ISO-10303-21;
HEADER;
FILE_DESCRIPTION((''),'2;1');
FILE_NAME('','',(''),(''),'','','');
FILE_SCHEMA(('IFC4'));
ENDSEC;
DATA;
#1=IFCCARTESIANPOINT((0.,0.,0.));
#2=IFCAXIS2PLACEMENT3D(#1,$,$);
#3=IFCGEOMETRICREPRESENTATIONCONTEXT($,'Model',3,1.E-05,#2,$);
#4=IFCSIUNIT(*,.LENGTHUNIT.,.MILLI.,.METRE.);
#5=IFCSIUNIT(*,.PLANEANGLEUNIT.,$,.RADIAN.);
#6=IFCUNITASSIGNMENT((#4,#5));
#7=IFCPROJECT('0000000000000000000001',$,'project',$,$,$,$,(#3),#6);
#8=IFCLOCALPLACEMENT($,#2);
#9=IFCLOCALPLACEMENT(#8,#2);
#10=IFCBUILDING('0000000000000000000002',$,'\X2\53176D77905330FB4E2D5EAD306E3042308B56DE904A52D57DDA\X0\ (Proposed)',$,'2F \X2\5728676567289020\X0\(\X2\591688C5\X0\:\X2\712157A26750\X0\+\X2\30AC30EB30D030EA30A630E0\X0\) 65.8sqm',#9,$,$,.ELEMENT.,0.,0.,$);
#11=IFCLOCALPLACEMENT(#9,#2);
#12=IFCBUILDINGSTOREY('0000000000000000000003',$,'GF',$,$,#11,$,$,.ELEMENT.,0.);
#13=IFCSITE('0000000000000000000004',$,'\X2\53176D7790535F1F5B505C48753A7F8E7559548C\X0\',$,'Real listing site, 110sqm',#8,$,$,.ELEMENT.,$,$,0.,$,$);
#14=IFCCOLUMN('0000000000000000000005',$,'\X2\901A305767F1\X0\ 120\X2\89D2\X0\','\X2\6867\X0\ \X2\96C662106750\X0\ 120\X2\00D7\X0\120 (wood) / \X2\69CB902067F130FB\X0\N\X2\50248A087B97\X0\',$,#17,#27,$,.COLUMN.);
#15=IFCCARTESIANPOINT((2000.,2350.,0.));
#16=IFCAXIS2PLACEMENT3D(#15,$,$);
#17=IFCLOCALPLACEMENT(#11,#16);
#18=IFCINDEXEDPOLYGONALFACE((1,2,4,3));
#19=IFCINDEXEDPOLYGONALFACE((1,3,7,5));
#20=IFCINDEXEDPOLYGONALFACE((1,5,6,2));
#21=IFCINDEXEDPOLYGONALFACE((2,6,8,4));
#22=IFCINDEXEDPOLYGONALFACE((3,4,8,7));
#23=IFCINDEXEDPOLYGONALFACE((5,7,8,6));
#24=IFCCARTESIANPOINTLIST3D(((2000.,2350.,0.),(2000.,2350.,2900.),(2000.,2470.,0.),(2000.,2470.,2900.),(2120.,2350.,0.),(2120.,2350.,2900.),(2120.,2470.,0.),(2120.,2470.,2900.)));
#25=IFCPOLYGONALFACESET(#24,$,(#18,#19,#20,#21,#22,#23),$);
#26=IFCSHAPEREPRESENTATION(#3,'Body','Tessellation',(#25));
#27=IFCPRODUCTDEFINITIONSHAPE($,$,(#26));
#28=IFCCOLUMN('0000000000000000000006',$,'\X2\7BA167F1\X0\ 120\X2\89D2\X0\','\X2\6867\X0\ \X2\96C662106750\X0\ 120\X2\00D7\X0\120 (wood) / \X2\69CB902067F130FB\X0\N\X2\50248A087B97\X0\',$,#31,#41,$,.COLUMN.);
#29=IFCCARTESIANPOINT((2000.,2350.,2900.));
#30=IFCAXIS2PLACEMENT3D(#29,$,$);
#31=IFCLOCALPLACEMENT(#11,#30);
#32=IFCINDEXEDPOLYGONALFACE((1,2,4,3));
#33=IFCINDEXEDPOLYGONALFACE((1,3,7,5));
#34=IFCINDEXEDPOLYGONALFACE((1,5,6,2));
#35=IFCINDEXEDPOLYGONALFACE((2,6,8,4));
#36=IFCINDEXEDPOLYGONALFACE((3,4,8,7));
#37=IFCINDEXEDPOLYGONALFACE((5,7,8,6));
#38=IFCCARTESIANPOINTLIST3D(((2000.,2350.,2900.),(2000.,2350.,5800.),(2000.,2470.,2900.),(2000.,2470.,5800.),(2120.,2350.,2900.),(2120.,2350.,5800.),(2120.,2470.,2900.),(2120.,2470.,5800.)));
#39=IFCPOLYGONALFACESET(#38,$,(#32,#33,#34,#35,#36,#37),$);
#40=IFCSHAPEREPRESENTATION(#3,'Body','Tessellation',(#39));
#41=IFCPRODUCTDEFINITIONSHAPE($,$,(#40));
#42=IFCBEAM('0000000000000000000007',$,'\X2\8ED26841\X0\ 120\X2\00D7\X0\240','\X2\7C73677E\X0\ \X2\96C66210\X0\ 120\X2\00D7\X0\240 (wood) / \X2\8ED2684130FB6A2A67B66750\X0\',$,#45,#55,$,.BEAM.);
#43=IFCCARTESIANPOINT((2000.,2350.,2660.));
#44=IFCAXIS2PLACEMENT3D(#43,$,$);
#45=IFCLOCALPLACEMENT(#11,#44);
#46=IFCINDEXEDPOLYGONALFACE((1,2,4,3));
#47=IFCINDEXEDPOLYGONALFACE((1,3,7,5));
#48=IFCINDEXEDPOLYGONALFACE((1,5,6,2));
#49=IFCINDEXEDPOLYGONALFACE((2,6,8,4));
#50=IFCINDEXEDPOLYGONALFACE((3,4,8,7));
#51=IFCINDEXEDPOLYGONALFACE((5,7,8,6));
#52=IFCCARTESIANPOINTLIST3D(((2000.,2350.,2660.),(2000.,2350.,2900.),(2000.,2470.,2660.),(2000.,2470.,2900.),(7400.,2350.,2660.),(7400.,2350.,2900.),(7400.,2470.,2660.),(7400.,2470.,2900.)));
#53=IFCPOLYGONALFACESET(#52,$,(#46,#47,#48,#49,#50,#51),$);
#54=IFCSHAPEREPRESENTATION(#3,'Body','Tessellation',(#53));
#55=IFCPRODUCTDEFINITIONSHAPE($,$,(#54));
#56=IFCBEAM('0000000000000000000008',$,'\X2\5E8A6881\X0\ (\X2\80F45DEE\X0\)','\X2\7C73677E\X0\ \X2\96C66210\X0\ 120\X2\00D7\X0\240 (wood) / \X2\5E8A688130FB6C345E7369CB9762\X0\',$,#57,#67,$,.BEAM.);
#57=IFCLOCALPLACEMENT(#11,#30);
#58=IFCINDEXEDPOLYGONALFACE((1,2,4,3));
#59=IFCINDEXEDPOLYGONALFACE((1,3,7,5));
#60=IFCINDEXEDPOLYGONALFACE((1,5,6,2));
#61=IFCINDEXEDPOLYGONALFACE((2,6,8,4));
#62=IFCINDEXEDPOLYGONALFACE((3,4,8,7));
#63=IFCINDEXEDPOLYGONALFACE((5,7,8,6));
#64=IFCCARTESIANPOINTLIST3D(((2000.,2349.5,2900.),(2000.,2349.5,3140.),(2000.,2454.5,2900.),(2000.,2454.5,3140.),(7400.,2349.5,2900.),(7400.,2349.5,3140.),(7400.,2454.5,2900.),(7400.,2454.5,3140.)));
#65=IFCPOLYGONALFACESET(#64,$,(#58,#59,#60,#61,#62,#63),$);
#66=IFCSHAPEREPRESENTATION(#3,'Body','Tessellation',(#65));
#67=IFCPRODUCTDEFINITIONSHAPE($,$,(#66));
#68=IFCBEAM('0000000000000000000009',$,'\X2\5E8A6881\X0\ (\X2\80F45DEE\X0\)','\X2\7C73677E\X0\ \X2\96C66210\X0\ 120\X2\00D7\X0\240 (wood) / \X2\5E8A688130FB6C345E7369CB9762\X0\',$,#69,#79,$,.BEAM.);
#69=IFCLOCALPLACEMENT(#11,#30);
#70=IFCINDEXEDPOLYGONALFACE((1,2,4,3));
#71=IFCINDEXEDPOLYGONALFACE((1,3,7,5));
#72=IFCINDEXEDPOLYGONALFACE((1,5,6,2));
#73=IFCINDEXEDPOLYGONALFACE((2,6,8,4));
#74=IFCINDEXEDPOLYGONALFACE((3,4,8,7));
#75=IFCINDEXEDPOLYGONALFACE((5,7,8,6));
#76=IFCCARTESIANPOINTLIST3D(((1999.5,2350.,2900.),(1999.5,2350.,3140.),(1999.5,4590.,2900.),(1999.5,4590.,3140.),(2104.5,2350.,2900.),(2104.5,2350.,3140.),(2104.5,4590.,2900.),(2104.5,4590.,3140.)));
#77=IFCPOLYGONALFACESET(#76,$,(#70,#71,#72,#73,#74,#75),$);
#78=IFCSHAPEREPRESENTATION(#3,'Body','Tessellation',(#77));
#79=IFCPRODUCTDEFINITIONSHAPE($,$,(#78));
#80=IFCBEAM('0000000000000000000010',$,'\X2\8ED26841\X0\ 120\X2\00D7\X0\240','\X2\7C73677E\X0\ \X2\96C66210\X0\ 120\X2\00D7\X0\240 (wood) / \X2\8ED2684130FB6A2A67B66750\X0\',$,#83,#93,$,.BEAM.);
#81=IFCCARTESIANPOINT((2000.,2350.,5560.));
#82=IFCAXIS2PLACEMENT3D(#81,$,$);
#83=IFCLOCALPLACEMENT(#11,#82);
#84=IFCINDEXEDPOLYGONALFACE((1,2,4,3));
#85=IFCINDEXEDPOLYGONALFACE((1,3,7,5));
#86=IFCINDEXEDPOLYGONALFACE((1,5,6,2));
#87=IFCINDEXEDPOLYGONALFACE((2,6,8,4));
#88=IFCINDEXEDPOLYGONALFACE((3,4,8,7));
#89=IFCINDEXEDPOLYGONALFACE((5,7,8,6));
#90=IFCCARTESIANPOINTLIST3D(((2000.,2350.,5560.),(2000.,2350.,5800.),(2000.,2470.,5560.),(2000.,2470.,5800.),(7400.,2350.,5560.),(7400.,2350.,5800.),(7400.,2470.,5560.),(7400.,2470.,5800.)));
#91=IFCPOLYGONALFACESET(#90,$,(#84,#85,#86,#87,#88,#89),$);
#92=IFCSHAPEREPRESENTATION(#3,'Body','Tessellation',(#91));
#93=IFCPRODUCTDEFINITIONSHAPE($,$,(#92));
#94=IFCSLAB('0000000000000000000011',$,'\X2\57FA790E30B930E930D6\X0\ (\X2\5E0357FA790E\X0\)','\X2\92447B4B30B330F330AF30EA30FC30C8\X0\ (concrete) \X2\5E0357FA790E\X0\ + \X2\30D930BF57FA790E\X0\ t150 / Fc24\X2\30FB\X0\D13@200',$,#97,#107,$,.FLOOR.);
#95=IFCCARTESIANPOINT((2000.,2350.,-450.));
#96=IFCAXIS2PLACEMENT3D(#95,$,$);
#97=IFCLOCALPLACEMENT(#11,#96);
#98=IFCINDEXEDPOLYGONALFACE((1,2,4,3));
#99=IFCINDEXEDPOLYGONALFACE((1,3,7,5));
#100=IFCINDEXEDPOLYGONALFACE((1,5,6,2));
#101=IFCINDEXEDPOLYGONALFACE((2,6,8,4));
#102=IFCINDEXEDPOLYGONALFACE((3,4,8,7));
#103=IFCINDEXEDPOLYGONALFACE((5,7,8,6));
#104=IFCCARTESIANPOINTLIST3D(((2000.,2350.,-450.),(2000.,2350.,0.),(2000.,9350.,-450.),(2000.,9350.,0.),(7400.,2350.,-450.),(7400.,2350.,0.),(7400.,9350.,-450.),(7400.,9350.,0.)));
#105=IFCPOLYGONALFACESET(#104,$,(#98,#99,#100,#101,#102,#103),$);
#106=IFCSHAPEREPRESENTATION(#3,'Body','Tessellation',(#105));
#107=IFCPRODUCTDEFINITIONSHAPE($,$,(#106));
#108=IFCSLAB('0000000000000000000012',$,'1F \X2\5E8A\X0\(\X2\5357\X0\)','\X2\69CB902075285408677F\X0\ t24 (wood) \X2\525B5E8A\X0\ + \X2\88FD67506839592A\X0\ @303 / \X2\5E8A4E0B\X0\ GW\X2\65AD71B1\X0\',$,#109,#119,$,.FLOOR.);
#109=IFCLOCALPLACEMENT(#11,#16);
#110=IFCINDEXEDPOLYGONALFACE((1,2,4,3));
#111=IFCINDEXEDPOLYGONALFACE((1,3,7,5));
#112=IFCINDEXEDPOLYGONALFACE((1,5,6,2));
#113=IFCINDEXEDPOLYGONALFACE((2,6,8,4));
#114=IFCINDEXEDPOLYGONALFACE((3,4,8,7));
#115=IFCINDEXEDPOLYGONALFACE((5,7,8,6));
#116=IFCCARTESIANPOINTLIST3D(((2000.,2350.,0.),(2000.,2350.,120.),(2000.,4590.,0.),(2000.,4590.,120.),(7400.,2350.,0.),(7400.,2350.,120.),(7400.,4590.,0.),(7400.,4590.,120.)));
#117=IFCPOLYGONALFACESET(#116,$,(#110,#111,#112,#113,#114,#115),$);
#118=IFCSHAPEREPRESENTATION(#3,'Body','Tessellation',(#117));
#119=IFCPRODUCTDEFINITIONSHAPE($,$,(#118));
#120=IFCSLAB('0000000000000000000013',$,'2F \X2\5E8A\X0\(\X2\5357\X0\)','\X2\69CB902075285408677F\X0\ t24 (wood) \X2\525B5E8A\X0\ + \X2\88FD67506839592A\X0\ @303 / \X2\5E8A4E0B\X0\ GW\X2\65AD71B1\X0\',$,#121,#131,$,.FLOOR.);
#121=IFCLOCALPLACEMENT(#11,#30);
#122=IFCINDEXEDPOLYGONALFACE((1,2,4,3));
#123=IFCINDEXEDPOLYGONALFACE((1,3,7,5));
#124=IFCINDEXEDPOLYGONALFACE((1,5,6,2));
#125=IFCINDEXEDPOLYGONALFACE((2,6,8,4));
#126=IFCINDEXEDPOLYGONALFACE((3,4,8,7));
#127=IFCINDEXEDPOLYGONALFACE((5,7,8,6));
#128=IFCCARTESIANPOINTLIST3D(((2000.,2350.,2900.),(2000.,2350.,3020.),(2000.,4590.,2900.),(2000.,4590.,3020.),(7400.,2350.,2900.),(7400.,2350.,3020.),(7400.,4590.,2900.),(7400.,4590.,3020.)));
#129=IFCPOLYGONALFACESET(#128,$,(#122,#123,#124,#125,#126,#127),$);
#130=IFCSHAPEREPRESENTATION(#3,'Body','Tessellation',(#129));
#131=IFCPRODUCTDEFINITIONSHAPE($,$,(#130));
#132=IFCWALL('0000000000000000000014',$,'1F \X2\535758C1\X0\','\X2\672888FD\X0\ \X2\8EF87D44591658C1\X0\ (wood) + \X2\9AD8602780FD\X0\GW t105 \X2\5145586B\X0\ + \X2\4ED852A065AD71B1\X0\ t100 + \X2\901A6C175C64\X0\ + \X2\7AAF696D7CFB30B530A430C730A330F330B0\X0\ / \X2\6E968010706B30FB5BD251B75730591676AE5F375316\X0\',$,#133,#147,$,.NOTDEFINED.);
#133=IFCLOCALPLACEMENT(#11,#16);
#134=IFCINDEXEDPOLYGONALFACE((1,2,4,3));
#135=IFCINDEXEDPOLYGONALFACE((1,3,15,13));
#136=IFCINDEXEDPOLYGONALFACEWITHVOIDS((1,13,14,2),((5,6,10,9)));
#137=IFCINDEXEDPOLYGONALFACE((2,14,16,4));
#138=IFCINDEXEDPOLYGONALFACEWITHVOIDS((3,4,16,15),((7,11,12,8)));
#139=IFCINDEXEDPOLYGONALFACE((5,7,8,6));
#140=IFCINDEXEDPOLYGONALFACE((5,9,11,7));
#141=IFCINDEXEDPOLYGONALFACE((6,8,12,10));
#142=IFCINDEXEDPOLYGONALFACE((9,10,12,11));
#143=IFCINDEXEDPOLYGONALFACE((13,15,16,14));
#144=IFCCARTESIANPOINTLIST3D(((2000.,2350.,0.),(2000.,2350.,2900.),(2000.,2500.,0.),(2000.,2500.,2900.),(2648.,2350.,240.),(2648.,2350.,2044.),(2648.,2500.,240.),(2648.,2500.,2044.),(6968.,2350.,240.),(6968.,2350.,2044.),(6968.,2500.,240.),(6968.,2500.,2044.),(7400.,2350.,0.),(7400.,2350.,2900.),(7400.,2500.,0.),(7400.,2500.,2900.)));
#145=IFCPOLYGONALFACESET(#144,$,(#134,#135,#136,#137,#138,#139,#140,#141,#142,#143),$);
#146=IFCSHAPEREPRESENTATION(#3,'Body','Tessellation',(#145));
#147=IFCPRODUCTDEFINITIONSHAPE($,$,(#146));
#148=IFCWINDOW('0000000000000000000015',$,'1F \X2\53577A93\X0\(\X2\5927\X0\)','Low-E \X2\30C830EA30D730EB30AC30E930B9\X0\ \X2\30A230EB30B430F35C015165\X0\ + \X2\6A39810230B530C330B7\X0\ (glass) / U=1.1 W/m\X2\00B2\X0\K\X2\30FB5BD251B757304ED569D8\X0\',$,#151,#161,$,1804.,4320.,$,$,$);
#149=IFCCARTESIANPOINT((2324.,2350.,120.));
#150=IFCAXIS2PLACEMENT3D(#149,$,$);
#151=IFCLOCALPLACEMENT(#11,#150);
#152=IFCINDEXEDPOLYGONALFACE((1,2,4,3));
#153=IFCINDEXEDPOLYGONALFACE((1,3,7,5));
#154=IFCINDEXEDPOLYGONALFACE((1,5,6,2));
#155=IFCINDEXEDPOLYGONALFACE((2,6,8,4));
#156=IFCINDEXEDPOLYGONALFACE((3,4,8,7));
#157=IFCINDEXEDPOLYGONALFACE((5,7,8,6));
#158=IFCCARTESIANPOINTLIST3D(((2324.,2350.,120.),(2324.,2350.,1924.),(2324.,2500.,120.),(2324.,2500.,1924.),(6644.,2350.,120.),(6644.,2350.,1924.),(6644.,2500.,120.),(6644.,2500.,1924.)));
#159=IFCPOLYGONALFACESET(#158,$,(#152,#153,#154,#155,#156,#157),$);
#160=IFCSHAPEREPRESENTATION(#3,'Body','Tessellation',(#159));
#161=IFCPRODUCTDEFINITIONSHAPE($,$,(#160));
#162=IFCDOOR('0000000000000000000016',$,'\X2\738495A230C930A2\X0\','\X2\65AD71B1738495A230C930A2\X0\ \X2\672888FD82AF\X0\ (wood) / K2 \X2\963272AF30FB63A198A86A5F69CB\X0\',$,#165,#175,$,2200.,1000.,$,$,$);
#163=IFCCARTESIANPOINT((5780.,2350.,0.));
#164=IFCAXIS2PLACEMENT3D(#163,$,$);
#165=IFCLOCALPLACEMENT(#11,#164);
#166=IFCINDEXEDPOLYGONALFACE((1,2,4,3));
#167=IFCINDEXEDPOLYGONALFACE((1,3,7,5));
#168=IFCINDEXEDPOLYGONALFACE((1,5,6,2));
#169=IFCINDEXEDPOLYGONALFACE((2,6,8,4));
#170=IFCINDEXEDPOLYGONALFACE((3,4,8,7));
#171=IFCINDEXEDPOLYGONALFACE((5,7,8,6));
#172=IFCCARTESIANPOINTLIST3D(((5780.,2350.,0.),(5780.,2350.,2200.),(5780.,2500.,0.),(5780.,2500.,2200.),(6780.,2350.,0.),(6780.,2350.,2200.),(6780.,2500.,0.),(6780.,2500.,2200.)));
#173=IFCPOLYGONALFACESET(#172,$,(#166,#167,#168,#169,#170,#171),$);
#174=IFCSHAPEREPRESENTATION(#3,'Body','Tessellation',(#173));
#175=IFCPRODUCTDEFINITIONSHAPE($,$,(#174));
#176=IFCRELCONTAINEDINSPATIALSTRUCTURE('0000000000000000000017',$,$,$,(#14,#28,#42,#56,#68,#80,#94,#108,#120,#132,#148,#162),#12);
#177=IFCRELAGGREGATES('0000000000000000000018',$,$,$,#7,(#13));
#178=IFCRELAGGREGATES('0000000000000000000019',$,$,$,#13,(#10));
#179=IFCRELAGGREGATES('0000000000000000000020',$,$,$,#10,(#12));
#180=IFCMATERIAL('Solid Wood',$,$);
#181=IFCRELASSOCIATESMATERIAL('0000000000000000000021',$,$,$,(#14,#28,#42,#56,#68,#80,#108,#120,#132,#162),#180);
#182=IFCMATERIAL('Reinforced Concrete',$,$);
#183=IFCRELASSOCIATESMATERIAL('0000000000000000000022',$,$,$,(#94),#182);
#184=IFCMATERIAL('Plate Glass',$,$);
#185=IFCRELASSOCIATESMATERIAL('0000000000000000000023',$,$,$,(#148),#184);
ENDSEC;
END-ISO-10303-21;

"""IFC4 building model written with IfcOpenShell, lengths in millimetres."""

from ifc_helpers import new_model, si_unit, frame, frame_2d, origin, place, context, project, spatial, rectangle, extrude, material, element, fill, save


model = new_model("IFC4")

# Units and contexts
model_context = context("Model", 3, precision=1e-05, world=origin())
ifc_project = project(units=[si_unit("LENGTHUNIT", "METRE", prefix="MILLI"), si_unit("PLANEANGLEUNIT", "RADIAN")], contexts=[model_context])

# Site, building, storey
site_placement = place(None, origin())
site = spatial("IfcSite", under=ifc_project, at=site_placement, Name="北海道弟子屈町美留和", ObjectType="Real listing site, 110sqm", CompositionType="ELEMENT", RefElevation=0.0)
building_placement = place(site_placement, origin())
building = spatial("IfcBuilding", under=site, at=building_placement, Name="北海道・中庭のある回遊動線 (Proposed)", ObjectType="2F 在来木造(外装:無垢材+ガルバリウム) 65.8sqm", CompositionType="ELEMENT", ElevationOfRefHeight=0.0, ElevationOfTerrain=0.0)
storey_placement = place(building_placement, origin())
storey = spatial("IfcBuildingStorey", under=building, at=storey_placement, Name="GF", CompositionType="ELEMENT", Elevation=0.0)

# Columns
ifc_material_1 = material(Name="Solid Wood")
column_1_placement = place(storey_placement, frame((2000.0, 2350.0, 0.0)))
element("IfcColumn", 1, at=column_1_placement, inside=storey, material=ifc_material_1, Name="通し柱 120角", Description="桧 集成材 120×120 (wood) / 構造柱・N値計算", PredefinedType="COLUMN", context=model_context, shape_type="SweptSolid", body=[
    extrude(rectangle(XDim=120.0, YDim=120.0, at=frame_2d((60.0, 60.0))), frame((2000.0, 2350.0, 0.0)), (0.0, 0.0, 1.0), 2900.0),
])
column_2_placement = place(storey_placement, frame((2000.0, 2350.0, 2900.0)))
element("IfcColumn", 2, at=column_2_placement, inside=storey, material=ifc_material_1, Name="管柱 120角", Description="桧 集成材 120×120 (wood) / 構造柱・N値計算", PredefinedType="COLUMN", context=model_context, shape_type="SweptSolid", body=[
    extrude(rectangle(XDim=120.0, YDim=120.0, at=frame_2d((60.0, 60.0))), frame((2000.0, 2350.0, 2900.0)), (0.0, 0.0, 1.0), 2900.0),
])

# Beams
beam_1_placement = place(storey_placement, frame((2000.0, 2350.0, 2660.0)))
element("IfcBeam", 3, at=beam_1_placement, inside=storey, material=ifc_material_1, Name="軒桁 120×240", Description="米松 集成 120×240 (wood) / 軒桁・横架材", PredefinedType="BEAM", context=model_context, shape_type="SweptSolid", body=[
    extrude(rectangle(XDim=5400.0, YDim=120.0, at=frame_2d((2700.0, 60.0))), frame((2000.0, 2350.0, 2660.0)), (0.0, 0.0, 1.0), 240.0),
])
beam_2_placement = place(storey_placement, frame((2000.0, 2350.0, 2900.0)))
element("IfcBeam", 4, at=beam_2_placement, inside=storey, material=ifc_material_1, Name="床梁 (胴差)", Description="米松 集成 120×240 (wood) / 床梁・水平構面", PredefinedType="BEAM", context=model_context, shape_type="SweptSolid", body=[
    extrude(rectangle(XDim=5400.0, YDim=105.0, at=frame_2d((2700.0, 52.0))), frame((2000.0, 2350.0, 2900.0)), (0.0, 0.0, 1.0), 240.0),
])
beam_3_placement = place(storey_placement, frame((2000.0, 2350.0, 2900.0)))
element("IfcBeam", 5, at=beam_3_placement, inside=storey, material=ifc_material_1, Name="床梁 (胴差)", Description="米松 集成 120×240 (wood) / 床梁・水平構面", PredefinedType="BEAM", context=model_context, shape_type="SweptSolid", body=[
    extrude(rectangle(XDim=105.0, YDim=2240.0, at=frame_2d((52.0, 1120.0))), frame((2000.0, 2350.0, 2900.0)), (0.0, 0.0, 1.0), 240.0),
])
beam_4_placement = place(storey_placement, frame((2000.0, 2350.0, 5560.0)))
element("IfcBeam", 6, at=beam_4_placement, inside=storey, material=ifc_material_1, Name="軒桁 120×240", Description="米松 集成 120×240 (wood) / 軒桁・横架材", PredefinedType="BEAM", context=model_context, shape_type="SweptSolid", body=[
    extrude(rectangle(XDim=5400.0, YDim=120.0, at=frame_2d((2700.0, 60.0))), frame((2000.0, 2350.0, 5560.0)), (0.0, 0.0, 1.0), 240.0),
])

# Slabs
ifc_material_2 = material(Name="Reinforced Concrete")
slab_1_placement = place(storey_placement, frame((2000.0, 2350.0, -450.0)))
element("IfcSlab", 7, at=slab_1_placement, inside=storey, material=ifc_material_2, Name="基礎スラブ (布基礎)", Description="鉄筋コンクリート (concrete) 布基礎 + ベタ基礎 t150 / Fc24・D13@200", PredefinedType="FLOOR", context=model_context, shape_type="SweptSolid", body=[
    extrude(rectangle(XDim=5400.0, YDim=7000.0, at=frame_2d((2700.0, 3500.0))), frame((2000.0, 2350.0, -450.0)), (0.0, 0.0, 1.0), 450.0),
])
slab_2_placement = place(storey_placement, frame((2000.0, 2350.0, 0.0)))
element("IfcSlab", 8, at=slab_2_placement, inside=storey, material=ifc_material_1, Name="1F 床(南)", Description="構造用合板 t24 (wood) 剛床 + 製材根太 @303 / 床下 GW断熱", PredefinedType="FLOOR", context=model_context, shape_type="SweptSolid", body=[
    extrude(rectangle(XDim=5400.0, YDim=2240.0, at=frame_2d((2700.0, 1120.0))), frame((2000.0, 2350.0, 0.0)), (0.0, 0.0, 1.0), 120.0),
])
slab_3_placement = place(storey_placement, frame((2000.0, 2350.0, 2900.0)))
element("IfcSlab", 9, at=slab_3_placement, inside=storey, material=ifc_material_1, Name="2F 床(南)", Description="構造用合板 t24 (wood) 剛床 + 製材根太 @303 / 床下 GW断熱", PredefinedType="FLOOR", context=model_context, shape_type="SweptSolid", body=[
    extrude(rectangle(XDim=5400.0, YDim=2240.0, at=frame_2d((2700.0, 1120.0))), frame((2000.0, 2350.0, 2900.0)), (0.0, 0.0, 1.0), 120.0),
])

# Wall, openings, window, door
wall_1_placement = place(storey_placement, frame((2000.0, 2350.0, 0.0)))
wall_1 = element("IfcWall", 10, at=wall_1_placement, inside=storey, material=ifc_material_1, Name="1F 南壁", Description="木製 軸組外壁 (wood) + 高性能GW t105 充填 + 付加断熱 t100 + 通気層 + 窯業系サイディング / 準耐火・寒冷地外皮強化", PredefinedType="NOTDEFINED", context=model_context, shape_type="SweptSolid", body=[
    extrude(rectangle(XDim=5400.0, YDim=150.0, at=frame_2d((2700.0, 75.0))), frame((2000.0, 2350.0, 0.0)), (0.0, 0.0, 1.0), 2900.0),
])
opening_1_placement = place(storey_placement, frame((2324.0, 2350.0, 120.0)))
opening_1 = element("IfcOpeningElement", 11, at=opening_1_placement, cuts=wall_1, PredefinedType="NOTDEFINED", context=model_context, shape_type="SweptSolid", body=[
    extrude(rectangle(XDim=4320.0, YDim=150.0, at=frame_2d((2160.0, 75.0))), frame((2324.0, 2350.0, 120.0)), (0.0, 0.0, 1.0), 1804.0),
])
opening_2_placement = place(storey_placement, frame((5780.0, 2350.0, 0.0)))
opening_2 = element("IfcOpeningElement", 12, at=opening_2_placement, cuts=wall_1, PredefinedType="NOTDEFINED", context=model_context, shape_type="SweptSolid", body=[
    extrude(rectangle(XDim=1000.0, YDim=150.0, at=frame_2d((500.0, 75.0))), frame((5780.0, 2350.0, 0.0)), (0.0, 0.0, 1.0), 2200.0),
])
ifc_material_3 = material(Name="Plate Glass")
window_1_placement = place(storey_placement, frame((2324.0, 2350.0, 120.0)))
window_1 = element("IfcWindow", 13, at=window_1_placement, inside=storey, material=ifc_material_3, Name="1F 南窓(大)", Description="Low-E トリプルガラス アルゴン封入 + 樹脂サッシ (glass) / U=1.1 W/m²K・寒冷地仕様", OverallHeight=1804.0, OverallWidth=4320.0, context=model_context, shape_type="SweptSolid", body=[
    extrude(rectangle(XDim=4320.0, YDim=150.0, at=frame_2d((2160.0, 75.0))), frame((2324.0, 2350.0, 120.0)), (0.0, 0.0, 1.0), 1804.0),
])
fill(opening_1, window_1)
door_placement = place(storey_placement, frame((5780.0, 2350.0, 0.0)))
door = element("IfcDoor", 14, at=door_placement, inside=storey, material=ifc_material_1, Name="玄関ドア", Description="断熱玄関ドア 木製芯 (wood) / K2 防犯・採風機構", OverallHeight=2200.0, OverallWidth=1000.0, context=model_context, shape_type="SweptSolid", body=[
    extrude(rectangle(XDim=1000.0, YDim=150.0, at=frame_2d((500.0, 75.0))), frame((5780.0, 2350.0, 0.0)), (0.0, 0.0, 1.0), 2200.0),
])
fill(opening_2, door)

save(model, "model.ifc")
